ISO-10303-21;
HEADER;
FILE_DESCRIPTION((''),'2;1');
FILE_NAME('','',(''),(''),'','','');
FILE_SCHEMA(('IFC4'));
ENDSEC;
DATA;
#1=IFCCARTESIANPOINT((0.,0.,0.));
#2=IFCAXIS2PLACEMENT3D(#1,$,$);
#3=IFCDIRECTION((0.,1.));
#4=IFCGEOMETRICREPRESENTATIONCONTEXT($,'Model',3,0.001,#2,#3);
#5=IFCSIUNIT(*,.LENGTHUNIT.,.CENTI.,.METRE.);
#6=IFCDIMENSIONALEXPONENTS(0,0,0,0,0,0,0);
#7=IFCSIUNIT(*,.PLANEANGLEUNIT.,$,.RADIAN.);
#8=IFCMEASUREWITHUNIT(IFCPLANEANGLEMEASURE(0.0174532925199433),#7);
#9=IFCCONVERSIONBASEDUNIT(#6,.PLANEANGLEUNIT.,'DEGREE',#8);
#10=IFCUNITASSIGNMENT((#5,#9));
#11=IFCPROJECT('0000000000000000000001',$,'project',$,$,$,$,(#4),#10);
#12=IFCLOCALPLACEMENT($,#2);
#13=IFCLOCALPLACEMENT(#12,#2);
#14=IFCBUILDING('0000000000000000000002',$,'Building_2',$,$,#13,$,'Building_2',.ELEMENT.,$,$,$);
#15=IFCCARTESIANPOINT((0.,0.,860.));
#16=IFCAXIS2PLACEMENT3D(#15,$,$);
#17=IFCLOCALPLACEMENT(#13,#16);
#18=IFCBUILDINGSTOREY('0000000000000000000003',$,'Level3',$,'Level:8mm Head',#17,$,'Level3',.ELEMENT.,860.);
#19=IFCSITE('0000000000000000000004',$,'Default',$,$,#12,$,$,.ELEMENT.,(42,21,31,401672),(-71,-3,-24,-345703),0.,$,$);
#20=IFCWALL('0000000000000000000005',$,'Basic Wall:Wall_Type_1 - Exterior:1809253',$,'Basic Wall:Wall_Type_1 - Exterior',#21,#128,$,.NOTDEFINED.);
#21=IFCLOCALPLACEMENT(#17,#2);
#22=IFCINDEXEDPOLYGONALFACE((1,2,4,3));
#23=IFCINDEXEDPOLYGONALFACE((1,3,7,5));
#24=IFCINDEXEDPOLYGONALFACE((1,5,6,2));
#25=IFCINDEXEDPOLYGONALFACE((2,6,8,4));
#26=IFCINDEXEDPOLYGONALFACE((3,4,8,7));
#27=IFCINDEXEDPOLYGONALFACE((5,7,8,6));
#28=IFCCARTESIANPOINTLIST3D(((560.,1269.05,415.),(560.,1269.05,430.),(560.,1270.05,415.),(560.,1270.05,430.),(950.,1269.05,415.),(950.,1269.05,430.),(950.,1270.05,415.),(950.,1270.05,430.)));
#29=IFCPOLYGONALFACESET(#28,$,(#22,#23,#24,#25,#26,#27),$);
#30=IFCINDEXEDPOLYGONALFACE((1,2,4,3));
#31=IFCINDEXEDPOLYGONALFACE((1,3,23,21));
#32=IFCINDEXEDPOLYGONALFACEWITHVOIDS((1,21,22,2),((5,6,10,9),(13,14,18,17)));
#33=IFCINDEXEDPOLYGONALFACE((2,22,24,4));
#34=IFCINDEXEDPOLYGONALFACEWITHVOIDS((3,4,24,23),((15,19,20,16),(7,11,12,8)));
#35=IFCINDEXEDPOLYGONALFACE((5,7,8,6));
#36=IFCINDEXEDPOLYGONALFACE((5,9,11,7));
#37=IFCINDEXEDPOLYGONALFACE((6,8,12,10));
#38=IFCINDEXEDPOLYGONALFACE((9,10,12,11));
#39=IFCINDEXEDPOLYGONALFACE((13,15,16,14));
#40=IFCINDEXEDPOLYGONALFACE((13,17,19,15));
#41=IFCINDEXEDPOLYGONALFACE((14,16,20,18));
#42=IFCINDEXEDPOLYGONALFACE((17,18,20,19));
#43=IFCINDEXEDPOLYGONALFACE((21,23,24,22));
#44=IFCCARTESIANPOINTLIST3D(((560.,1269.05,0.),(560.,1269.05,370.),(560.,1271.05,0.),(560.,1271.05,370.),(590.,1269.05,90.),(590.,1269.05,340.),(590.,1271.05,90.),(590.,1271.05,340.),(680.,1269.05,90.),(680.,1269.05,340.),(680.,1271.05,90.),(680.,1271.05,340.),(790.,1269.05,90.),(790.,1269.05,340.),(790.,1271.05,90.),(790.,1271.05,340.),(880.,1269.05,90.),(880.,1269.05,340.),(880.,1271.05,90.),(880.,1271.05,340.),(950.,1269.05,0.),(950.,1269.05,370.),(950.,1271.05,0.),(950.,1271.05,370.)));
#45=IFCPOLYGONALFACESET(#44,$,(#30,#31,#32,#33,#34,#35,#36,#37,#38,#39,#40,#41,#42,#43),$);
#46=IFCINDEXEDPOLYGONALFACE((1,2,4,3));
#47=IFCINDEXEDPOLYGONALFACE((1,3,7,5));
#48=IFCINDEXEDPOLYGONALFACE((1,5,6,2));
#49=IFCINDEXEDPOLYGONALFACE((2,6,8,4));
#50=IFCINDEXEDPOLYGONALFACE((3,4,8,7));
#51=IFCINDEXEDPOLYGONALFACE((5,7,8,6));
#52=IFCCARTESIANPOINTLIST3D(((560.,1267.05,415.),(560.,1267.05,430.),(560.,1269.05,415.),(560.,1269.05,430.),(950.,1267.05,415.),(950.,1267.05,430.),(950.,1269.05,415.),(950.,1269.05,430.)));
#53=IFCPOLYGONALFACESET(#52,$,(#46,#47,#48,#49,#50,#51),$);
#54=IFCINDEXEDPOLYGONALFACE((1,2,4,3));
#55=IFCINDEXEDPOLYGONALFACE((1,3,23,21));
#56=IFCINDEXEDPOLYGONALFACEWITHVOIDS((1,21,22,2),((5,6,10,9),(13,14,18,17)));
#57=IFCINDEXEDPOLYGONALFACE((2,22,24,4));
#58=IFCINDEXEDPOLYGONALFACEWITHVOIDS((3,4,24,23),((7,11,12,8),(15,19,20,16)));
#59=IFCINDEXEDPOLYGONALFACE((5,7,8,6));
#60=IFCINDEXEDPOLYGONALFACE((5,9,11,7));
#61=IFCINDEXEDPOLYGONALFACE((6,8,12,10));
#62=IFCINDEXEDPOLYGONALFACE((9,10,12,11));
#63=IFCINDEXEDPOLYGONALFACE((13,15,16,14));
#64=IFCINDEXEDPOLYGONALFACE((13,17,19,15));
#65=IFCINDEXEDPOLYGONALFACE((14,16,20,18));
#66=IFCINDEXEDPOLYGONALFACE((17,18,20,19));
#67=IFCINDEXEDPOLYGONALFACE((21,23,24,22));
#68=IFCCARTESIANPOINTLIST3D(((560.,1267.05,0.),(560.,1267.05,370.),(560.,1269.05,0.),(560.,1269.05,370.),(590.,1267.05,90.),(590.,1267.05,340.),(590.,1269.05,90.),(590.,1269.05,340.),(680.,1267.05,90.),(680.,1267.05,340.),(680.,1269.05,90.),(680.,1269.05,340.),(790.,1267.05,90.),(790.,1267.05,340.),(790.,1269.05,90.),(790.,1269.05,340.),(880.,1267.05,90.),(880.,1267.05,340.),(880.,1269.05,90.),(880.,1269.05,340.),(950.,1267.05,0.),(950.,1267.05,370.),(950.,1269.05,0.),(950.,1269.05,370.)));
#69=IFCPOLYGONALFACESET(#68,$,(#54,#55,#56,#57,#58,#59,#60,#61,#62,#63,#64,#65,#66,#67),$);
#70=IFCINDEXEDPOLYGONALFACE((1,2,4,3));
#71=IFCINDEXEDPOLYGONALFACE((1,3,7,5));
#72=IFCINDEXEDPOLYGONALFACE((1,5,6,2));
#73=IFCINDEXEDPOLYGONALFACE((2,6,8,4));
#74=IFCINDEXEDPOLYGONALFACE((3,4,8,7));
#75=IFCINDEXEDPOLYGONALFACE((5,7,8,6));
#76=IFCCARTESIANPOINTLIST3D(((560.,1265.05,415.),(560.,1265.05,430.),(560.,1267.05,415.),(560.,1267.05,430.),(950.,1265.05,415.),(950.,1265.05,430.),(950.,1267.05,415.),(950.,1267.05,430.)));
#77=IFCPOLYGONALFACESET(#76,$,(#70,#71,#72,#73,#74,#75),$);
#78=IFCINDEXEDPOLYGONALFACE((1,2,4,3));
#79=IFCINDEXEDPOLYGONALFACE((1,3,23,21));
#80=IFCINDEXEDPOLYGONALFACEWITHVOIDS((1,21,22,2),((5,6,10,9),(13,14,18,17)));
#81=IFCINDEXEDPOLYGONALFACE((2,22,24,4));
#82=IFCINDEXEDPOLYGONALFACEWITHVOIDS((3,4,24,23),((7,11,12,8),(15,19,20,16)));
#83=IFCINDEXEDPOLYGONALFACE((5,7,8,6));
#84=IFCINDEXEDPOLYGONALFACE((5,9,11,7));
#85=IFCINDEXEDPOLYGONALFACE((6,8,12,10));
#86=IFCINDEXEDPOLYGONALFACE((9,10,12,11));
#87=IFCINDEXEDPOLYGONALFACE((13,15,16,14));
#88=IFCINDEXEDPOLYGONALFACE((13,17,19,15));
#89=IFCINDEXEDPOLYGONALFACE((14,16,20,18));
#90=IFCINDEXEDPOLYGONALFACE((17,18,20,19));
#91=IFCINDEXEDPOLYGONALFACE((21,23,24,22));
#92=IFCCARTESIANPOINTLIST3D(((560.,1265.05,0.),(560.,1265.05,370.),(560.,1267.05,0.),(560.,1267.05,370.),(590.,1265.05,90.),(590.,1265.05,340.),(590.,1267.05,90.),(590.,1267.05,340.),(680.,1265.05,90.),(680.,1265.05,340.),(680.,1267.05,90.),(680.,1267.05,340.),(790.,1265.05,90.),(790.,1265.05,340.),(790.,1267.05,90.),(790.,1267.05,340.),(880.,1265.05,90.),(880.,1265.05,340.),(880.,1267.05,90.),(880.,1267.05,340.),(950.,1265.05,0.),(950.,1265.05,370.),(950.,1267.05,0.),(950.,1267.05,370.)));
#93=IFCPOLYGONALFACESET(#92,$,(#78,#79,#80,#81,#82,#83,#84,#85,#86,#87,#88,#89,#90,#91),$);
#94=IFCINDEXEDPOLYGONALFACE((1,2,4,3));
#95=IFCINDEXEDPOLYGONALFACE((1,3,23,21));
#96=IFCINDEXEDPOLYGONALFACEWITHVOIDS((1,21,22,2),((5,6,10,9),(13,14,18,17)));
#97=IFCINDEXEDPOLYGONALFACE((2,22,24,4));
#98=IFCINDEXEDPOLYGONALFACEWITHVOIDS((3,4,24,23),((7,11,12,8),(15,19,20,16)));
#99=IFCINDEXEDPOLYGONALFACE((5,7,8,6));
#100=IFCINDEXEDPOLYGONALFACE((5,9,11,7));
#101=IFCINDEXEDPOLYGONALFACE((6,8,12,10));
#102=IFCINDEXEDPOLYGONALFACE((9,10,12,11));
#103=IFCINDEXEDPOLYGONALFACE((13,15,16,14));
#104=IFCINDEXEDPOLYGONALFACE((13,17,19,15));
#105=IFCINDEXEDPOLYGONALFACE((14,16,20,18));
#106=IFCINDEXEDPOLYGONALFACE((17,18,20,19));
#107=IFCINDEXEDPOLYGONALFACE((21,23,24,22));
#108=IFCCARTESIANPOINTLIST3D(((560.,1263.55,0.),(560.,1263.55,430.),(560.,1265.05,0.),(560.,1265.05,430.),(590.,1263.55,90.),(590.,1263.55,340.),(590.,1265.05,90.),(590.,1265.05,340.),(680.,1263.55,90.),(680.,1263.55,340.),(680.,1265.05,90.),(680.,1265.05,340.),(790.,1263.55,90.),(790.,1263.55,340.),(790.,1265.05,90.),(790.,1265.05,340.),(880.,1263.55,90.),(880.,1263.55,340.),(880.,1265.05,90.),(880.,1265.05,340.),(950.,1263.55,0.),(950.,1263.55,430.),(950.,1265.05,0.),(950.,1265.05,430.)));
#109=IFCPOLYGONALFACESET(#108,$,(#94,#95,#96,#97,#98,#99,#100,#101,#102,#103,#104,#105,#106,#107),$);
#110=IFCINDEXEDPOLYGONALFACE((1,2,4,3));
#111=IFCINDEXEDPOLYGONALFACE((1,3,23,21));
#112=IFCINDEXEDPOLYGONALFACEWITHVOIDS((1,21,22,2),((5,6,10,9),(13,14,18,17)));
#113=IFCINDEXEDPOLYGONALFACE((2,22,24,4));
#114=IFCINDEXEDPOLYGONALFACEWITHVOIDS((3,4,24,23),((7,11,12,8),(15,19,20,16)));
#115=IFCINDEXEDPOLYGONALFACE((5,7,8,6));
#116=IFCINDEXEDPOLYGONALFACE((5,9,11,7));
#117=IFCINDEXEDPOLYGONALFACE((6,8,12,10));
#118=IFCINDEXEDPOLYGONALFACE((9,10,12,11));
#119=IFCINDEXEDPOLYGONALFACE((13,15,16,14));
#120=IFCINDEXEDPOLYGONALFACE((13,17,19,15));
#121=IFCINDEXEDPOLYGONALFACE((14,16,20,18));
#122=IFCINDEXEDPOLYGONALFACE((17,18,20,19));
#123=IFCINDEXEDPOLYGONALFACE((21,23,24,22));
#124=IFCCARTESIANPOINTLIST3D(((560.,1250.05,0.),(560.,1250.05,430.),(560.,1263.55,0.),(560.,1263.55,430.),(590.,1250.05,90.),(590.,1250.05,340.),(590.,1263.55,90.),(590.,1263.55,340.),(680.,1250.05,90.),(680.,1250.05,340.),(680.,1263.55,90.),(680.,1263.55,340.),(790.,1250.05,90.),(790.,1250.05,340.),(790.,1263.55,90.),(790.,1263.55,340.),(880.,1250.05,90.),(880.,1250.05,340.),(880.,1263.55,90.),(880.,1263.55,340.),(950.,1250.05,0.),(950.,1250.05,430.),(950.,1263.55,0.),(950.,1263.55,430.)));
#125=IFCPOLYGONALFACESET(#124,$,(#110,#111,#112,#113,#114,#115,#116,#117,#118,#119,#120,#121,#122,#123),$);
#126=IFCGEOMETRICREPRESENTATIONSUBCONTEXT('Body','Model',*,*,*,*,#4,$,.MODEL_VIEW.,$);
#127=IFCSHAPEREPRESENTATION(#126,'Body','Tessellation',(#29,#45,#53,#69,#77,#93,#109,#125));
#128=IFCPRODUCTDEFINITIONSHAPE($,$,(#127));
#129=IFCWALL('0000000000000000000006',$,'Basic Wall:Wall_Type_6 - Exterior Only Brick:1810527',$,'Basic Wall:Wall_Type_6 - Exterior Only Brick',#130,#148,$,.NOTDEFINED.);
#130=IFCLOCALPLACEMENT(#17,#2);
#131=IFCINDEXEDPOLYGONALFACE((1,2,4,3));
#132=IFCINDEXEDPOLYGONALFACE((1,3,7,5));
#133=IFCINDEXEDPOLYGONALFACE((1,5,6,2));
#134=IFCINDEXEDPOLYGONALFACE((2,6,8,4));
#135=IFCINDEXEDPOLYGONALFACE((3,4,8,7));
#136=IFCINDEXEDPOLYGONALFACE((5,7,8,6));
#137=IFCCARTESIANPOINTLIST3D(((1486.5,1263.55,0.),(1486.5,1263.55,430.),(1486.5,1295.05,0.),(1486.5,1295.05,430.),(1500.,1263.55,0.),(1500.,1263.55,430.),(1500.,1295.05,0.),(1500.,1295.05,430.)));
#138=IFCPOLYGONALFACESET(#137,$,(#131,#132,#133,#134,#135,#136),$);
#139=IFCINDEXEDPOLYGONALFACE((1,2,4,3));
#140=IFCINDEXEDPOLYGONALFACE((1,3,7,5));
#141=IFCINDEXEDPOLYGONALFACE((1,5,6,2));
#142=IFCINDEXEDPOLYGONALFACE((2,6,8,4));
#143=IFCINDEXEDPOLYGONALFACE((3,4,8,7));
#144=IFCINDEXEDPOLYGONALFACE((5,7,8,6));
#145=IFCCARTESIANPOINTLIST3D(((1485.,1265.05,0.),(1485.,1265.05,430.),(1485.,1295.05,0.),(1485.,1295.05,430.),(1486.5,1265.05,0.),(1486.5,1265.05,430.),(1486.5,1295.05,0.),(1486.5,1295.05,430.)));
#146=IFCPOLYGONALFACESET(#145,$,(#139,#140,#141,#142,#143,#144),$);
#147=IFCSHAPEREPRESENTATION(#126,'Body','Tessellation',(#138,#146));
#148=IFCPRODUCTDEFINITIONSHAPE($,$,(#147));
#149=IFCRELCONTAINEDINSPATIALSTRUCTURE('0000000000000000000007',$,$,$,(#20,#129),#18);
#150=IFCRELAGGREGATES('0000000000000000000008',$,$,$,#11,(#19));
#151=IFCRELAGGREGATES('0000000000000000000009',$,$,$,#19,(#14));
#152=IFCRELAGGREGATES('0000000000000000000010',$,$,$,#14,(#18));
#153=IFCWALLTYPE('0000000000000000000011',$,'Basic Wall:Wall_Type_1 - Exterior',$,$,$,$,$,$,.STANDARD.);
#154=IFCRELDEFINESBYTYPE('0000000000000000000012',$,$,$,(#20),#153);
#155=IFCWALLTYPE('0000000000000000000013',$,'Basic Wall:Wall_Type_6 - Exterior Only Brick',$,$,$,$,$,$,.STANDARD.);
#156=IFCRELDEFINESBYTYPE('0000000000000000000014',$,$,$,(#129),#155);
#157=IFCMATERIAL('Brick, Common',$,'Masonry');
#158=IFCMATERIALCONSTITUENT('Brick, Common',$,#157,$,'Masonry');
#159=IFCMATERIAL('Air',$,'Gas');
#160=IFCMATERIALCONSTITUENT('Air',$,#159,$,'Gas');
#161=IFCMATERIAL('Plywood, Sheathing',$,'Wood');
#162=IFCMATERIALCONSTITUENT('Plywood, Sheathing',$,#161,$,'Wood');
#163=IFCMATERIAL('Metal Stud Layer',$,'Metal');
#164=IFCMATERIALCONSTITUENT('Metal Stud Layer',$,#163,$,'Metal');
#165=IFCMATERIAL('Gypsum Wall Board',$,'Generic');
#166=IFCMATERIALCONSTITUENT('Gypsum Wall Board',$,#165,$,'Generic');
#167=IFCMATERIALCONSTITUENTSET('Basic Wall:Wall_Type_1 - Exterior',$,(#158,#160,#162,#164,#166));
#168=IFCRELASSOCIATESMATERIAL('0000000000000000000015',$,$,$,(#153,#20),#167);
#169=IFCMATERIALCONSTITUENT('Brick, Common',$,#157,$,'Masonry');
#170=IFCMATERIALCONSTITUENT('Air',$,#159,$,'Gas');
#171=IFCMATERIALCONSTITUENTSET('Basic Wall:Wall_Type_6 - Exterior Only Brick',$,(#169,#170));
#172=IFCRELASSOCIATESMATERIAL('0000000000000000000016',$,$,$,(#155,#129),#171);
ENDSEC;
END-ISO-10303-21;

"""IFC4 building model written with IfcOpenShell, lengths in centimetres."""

from ifc_helpers import new_model, entity, si_unit, converted_unit, direction, frame, origin, place, context, subcontext, project, spatial, indexed_curve, outline, extrude, material, constituent, constituent_set, type_object, element, save


model = new_model("IFC4")

# Units and contexts
model_context = context("Model", 3, precision=0.001, world=origin(), true_north=direction((0.0, 1.0)))
body_context = subcontext(model_context, "Body", "Model", "MODEL_VIEW")
ifc_project = project(units=[si_unit("LENGTHUNIT", "METRE", prefix="CENTI"), converted_unit("PLANEANGLEUNIT", "DEGREE", entity("IfcPlaneAngleMeasure", 0.0174532925199433), si_unit("PLANEANGLEUNIT", "RADIAN"), dimensions=[0, 0, 0, 0, 0, 0, 0])], contexts=[model_context])

# Site, building, storey
site_placement = place(None, origin())
site = spatial("IfcSite", under=ifc_project, at=site_placement, Name="Default", CompositionType="ELEMENT", RefLatitude=(42, 21, 31, 401672), RefLongitude=(-71, -3, -24, -345703), RefElevation=0.0)
building_placement = place(site_placement, origin())
building = spatial("IfcBuilding", under=site, at=building_placement, Name="Building_2", LongName="Building_2", CompositionType="ELEMENT")
storey_placement = place(building_placement, frame((0.0, 0.0, 860.0)))
storey = spatial("IfcBuildingStorey", under=building, at=storey_placement, Name="Level3", ObjectType="Level:8mm Head", LongName="Level3", CompositionType="ELEMENT", Elevation=860.0)

# Shared definitions
ifc_material_1 = material(Name="Brick, Common", Category="Masonry")
ifc_constituent_1 = constituent(ifc_material_1, Name="Brick, Common", Category="Masonry")
ifc_material_2 = material(Name="Air", Category="Gas")
ifc_constituent_2 = constituent(ifc_material_2, Name="Air", Category="Gas")
ifc_material_3 = material(Name="Plywood, Sheathing", Category="Wood")
ifc_constituent_3 = constituent(ifc_material_3, Name="Plywood, Sheathing", Category="Wood")
ifc_material_4 = material(Name="Metal Stud Layer", Category="Metal")
ifc_constituent_4 = constituent(ifc_material_4, Name="Metal Stud Layer", Category="Metal")
ifc_material_5 = material(Name="Gypsum Wall Board", Category="Generic")
ifc_constituent_5 = constituent(ifc_material_5, Name="Gypsum Wall Board", Category="Generic")
ifc_constituent_set_1 = constituent_set(constituents=[ifc_constituent_1, ifc_constituent_2, ifc_constituent_3, ifc_constituent_4, ifc_constituent_5], Name="Basic Wall:Wall_Type_1 - Exterior")
wall_type_1 = type_object("IfcWallType", Name="Basic Wall:Wall_Type_1 - Exterior", PredefinedType="STANDARD", material=ifc_constituent_set_1)

# Wall, openings
wall_1_placement = place(storey_placement, frame((950.0, 1260.55, 0.0), z_axis=(0.0, 0.0, 1.0), x_axis=(-1.0, 0.0, 0.0)))
wall_1 = element("IfcWall", 1, at=wall_1_placement, inside=storey, type_object=wall_type_1, material=ifc_constituent_set_1, Name="Basic Wall:Wall_Type_1 - Exterior:1809253", ObjectType="Basic Wall:Wall_Type_1 - Exterior", PredefinedType="NOTDEFINED", context=body_context, shape_type="SweptSolid", body=[
    extrude(outline(indexed_curve([(-0.5, -7.5), (0.5, -7.5), (0.5, 7.5), (-0.5, 7.5), (-0.5, -7.5)], self_intersect=False)), frame((390.0, -9.0, 422.5), z_axis=(-1.0, 0.0, 0.0), x_axis=(0.0, 1.0, 0.0)), (0.0, 0.0, 1.0), 390.0),
    extrude(outline(indexed_curve([(-185.0, -195.0), (185.0, -195.0), (185.0, 195.0), (-185.0, 195.0), (-185.0, -195.0)], self_intersect=False), holes=[indexed_curve([(155.0, -165.0), (-95.0, -165.0), (-95.0, -75.0), (155.0, -75.0), (155.0, -165.0)], self_intersect=False), indexed_curve([(155.0, 35.0), (-95.0, 35.0), (-95.0, 125.0), (155.0, 125.0), (155.0, 35.0)], self_intersect=False)]), frame((195.0, -8.5, 185.0), z_axis=(0.0, -1.0, 0.0), x_axis=(0.0, 0.0, 1.0)), (0.0, 0.0, 1.0), 2.0),
    extrude(outline(indexed_curve([(-7.5, -1.0), (7.5, -1.0), (7.5, 1.0), (-7.5, 1.0), (-7.5, -1.0)], self_intersect=False)), frame((390.0, -7.5, 422.5), z_axis=(-1.0, 0.0, 0.0), x_axis=(0.0, 0.0, 1.0)), (0.0, 0.0, 1.0), 390.0),
    extrude(outline(indexed_curve([(-185.0, -195.0), (185.0, -195.0), (185.0, 195.0), (-185.0, 195.0), (-185.0, -195.0)], self_intersect=False), holes=[indexed_curve([(155.0, -165.0), (-95.0, -165.0), (-95.0, -75.0), (155.0, -75.0), (155.0, -165.0)], self_intersect=False), indexed_curve([(155.0, 35.0), (-95.0, 35.0), (-95.0, 125.0), (155.0, 125.0), (155.0, 35.0)], self_intersect=False)]), frame((195.0, -6.5, 185.0), z_axis=(0.0, -1.0, 0.0), x_axis=(0.0, 0.0, 1.0)), (0.0, 0.0, 1.0), 2.0),
    extrude(outline(indexed_curve([(-7.5, -1.0), (7.5, -1.0), (7.5, 1.0), (-7.5, 1.0), (-7.5, -1.0)], self_intersect=False)), frame((390.0, -5.5, 422.5), z_axis=(-1.0, 0.0, 0.0), x_axis=(0.0, 0.0, 1.0)), (0.0, 0.0, 1.0), 390.0),
    extrude(outline(indexed_curve([(-185.0, -195.0), (185.0, -195.0), (185.0, 195.0), (-185.0, 195.0), (-185.0, -195.0)], self_intersect=False), holes=[indexed_curve([(155.0, -165.0), (-95.0, -165.0), (-95.0, -75.0), (155.0, -75.0), (155.0, -165.0)], self_intersect=False), indexed_curve([(155.0, 35.0), (-95.0, 35.0), (-95.0, 125.0), (155.0, 125.0), (155.0, 35.0)], self_intersect=False)]), frame((195.0, -4.5, 185.0), z_axis=(0.0, -1.0, 0.0), x_axis=(0.0, 0.0, 1.0)), (0.0, 0.0, 1.0), 2.0),
    extrude(outline(indexed_curve([(-215.0, -195.0), (215.0, -195.0), (215.0, 195.0), (-215.0, 195.0), (-215.0, -195.0)], self_intersect=False), holes=[indexed_curve([(125.0, -165.0), (-125.0, -165.0), (-125.0, -75.0), (125.0, -75.0), (125.0, -165.0)], self_intersect=False), indexed_curve([(125.0, 35.0), (-125.0, 35.0), (-125.0, 125.0), (125.0, 125.0), (125.0, 35.0)], self_intersect=False)]), frame((195.0, -3.0, 215.0), z_axis=(0.0, -1.0, 0.0), x_axis=(0.0, 0.0, 1.0)), (0.0, 0.0, 1.0), 1.5),
    extrude(outline(indexed_curve([(-215.0, -195.0), (215.0, -195.0), (215.0, 195.0), (-215.0, 195.0), (-215.0, -195.0)], self_intersect=False), holes=[indexed_curve([(125.0, 35.0), (-125.0, 35.0), (-125.0, 125.0), (125.0, 125.0), (125.0, 35.0)], self_intersect=False), indexed_curve([(125.0, -165.0), (-125.0, -165.0), (-125.0, -75.0), (125.0, -75.0), (125.0, -165.0)], self_intersect=False)]), frame((195.0, 10.5, 215.0), z_axis=(0.0, -1.0, 0.0), x_axis=(0.0, 0.0, 1.0)), (0.0, 0.0, 1.0), 13.5),
])
opening_1_placement = place(wall_1_placement, frame((360.0, 10.5, 90.0)))
element("IfcOpeningElement", 2, at=opening_1_placement, cuts=wall_1, PredefinedType="OPENING", context=body_context, shape_type="SweptSolid", body=[
    extrude(outline(indexed_curve([(250.0, 90.0), (0.0, 90.0), (0.0, 0.0), (250.0, 0.0), (250.0, 90.0)], self_intersect=False)), frame((0.0, 0.0, 0.0), z_axis=(0.0, -1.0, 0.0), x_axis=(0.0, 0.0, 1.0)), (0.0, 0.0, 1.0), 21.0),
])
opening_2_placement = place(wall_1_placement, frame((950.0, 1260.55, 0.0), z_axis=(0.0, 0.0, 1.0), x_axis=(-1.0, 0.0, 0.0)))
element("IfcOpeningElement", 3, at=opening_2_placement, cuts=wall_1, PredefinedType="OPENING", context=body_context, shape_type="SweptSolid", body=[
    extrude(outline(indexed_curve([(-45.0, -125.0), (45.0, -125.0), (45.0, 125.0), (-45.0, 125.0), (-45.0, -125.0)], self_intersect=False)), frame((635.0, 1402.45, 215.0), z_axis=(0.0, -1.0, 0.0), x_axis=(-1.0, 0.0, 0.0)), (0.0, 0.0, 1.0), 304.8),
])
opening_3_placement = place(wall_1_placement, frame((160.0, 10.5, 90.0)))
element("IfcOpeningElement", 4, at=opening_3_placement, cuts=wall_1, PredefinedType="OPENING", context=body_context, shape_type="SweptSolid", body=[
    extrude(outline(indexed_curve([(250.0, 90.0), (0.0, 90.0), (0.0, 0.0), (250.0, 0.0), (250.0, 90.0)], self_intersect=False)), frame((0.0, 0.0, 0.0), z_axis=(0.0, -1.0, 0.0), x_axis=(0.0, 0.0, 1.0)), (0.0, 0.0, 1.0), 21.0),
])
opening_4_placement = place(wall_1_placement, frame((950.0, 1260.55, 0.0), z_axis=(0.0, 0.0, 1.0), x_axis=(-1.0, 0.0, 0.0)))
element("IfcOpeningElement", 5, at=opening_4_placement, cuts=wall_1, PredefinedType="OPENING", context=body_context, shape_type="SweptSolid", body=[
    extrude(outline(indexed_curve([(-45.0, -125.0), (45.0, -125.0), (45.0, 125.0), (-45.0, 125.0), (-45.0, -125.0)], self_intersect=False)), frame((835.0, 1402.45, 215.0), z_axis=(0.0, -1.0, 0.0), x_axis=(-1.0, 0.0, 0.0)), (0.0, 0.0, 1.0), 304.8),
])

# Wall
ifc_constituent_6 = constituent(ifc_material_1, Name="Brick, Common", Category="Masonry")
ifc_constituent_7 = constituent(ifc_material_2, Name="Air", Category="Gas")
ifc_constituent_set_2 = constituent_set(constituents=[ifc_constituent_6, ifc_constituent_7], Name="Basic Wall:Wall_Type_6 - Exterior Only Brick")
wall_type_2 = type_object("IfcWallType", Name="Basic Wall:Wall_Type_6 - Exterior Only Brick", PredefinedType="STANDARD", material=ifc_constituent_set_2)
wall_2_placement = place(storey_placement, frame((1492.5, 1265.05, 0.0), z_axis=(0.0, 0.0, 1.0), x_axis=(0.0, 1.0, 0.0)))
element("IfcWall", 6, at=wall_2_placement, inside=storey, type_object=wall_type_2, material=ifc_constituent_set_2, Name="Basic Wall:Wall_Type_6 - Exterior Only Brick:1810527", ObjectType="Basic Wall:Wall_Type_6 - Exterior Only Brick", PredefinedType="NOTDEFINED", context=body_context, shape_type="SweptSolid", body=[
    extrude(outline(indexed_curve([(-6.75, -15.75), (6.75, -15.75), (6.75, 15.75), (-6.75, 15.75), (-6.75, -15.75)], self_intersect=False)), frame((14.25, -0.75, 0.0), z_axis=(0.0, 0.0, 1.0), x_axis=(0.0, 1.0, 0.0)), (0.0, 0.0, 1.0), 430.0),
    extrude(outline(indexed_curve([(-0.75, -15.0), (0.75, -15.0), (0.75, 15.0), (-0.75, 15.0), (-0.75, -15.0)], self_intersect=False)), frame((15.0, 6.75, 0.0), z_axis=(0.0, 0.0, 1.0), x_axis=(0.0, -1.0, 0.0)), (0.0, 0.0, 1.0), 430.0),
])

save(model, "model.ifc")
